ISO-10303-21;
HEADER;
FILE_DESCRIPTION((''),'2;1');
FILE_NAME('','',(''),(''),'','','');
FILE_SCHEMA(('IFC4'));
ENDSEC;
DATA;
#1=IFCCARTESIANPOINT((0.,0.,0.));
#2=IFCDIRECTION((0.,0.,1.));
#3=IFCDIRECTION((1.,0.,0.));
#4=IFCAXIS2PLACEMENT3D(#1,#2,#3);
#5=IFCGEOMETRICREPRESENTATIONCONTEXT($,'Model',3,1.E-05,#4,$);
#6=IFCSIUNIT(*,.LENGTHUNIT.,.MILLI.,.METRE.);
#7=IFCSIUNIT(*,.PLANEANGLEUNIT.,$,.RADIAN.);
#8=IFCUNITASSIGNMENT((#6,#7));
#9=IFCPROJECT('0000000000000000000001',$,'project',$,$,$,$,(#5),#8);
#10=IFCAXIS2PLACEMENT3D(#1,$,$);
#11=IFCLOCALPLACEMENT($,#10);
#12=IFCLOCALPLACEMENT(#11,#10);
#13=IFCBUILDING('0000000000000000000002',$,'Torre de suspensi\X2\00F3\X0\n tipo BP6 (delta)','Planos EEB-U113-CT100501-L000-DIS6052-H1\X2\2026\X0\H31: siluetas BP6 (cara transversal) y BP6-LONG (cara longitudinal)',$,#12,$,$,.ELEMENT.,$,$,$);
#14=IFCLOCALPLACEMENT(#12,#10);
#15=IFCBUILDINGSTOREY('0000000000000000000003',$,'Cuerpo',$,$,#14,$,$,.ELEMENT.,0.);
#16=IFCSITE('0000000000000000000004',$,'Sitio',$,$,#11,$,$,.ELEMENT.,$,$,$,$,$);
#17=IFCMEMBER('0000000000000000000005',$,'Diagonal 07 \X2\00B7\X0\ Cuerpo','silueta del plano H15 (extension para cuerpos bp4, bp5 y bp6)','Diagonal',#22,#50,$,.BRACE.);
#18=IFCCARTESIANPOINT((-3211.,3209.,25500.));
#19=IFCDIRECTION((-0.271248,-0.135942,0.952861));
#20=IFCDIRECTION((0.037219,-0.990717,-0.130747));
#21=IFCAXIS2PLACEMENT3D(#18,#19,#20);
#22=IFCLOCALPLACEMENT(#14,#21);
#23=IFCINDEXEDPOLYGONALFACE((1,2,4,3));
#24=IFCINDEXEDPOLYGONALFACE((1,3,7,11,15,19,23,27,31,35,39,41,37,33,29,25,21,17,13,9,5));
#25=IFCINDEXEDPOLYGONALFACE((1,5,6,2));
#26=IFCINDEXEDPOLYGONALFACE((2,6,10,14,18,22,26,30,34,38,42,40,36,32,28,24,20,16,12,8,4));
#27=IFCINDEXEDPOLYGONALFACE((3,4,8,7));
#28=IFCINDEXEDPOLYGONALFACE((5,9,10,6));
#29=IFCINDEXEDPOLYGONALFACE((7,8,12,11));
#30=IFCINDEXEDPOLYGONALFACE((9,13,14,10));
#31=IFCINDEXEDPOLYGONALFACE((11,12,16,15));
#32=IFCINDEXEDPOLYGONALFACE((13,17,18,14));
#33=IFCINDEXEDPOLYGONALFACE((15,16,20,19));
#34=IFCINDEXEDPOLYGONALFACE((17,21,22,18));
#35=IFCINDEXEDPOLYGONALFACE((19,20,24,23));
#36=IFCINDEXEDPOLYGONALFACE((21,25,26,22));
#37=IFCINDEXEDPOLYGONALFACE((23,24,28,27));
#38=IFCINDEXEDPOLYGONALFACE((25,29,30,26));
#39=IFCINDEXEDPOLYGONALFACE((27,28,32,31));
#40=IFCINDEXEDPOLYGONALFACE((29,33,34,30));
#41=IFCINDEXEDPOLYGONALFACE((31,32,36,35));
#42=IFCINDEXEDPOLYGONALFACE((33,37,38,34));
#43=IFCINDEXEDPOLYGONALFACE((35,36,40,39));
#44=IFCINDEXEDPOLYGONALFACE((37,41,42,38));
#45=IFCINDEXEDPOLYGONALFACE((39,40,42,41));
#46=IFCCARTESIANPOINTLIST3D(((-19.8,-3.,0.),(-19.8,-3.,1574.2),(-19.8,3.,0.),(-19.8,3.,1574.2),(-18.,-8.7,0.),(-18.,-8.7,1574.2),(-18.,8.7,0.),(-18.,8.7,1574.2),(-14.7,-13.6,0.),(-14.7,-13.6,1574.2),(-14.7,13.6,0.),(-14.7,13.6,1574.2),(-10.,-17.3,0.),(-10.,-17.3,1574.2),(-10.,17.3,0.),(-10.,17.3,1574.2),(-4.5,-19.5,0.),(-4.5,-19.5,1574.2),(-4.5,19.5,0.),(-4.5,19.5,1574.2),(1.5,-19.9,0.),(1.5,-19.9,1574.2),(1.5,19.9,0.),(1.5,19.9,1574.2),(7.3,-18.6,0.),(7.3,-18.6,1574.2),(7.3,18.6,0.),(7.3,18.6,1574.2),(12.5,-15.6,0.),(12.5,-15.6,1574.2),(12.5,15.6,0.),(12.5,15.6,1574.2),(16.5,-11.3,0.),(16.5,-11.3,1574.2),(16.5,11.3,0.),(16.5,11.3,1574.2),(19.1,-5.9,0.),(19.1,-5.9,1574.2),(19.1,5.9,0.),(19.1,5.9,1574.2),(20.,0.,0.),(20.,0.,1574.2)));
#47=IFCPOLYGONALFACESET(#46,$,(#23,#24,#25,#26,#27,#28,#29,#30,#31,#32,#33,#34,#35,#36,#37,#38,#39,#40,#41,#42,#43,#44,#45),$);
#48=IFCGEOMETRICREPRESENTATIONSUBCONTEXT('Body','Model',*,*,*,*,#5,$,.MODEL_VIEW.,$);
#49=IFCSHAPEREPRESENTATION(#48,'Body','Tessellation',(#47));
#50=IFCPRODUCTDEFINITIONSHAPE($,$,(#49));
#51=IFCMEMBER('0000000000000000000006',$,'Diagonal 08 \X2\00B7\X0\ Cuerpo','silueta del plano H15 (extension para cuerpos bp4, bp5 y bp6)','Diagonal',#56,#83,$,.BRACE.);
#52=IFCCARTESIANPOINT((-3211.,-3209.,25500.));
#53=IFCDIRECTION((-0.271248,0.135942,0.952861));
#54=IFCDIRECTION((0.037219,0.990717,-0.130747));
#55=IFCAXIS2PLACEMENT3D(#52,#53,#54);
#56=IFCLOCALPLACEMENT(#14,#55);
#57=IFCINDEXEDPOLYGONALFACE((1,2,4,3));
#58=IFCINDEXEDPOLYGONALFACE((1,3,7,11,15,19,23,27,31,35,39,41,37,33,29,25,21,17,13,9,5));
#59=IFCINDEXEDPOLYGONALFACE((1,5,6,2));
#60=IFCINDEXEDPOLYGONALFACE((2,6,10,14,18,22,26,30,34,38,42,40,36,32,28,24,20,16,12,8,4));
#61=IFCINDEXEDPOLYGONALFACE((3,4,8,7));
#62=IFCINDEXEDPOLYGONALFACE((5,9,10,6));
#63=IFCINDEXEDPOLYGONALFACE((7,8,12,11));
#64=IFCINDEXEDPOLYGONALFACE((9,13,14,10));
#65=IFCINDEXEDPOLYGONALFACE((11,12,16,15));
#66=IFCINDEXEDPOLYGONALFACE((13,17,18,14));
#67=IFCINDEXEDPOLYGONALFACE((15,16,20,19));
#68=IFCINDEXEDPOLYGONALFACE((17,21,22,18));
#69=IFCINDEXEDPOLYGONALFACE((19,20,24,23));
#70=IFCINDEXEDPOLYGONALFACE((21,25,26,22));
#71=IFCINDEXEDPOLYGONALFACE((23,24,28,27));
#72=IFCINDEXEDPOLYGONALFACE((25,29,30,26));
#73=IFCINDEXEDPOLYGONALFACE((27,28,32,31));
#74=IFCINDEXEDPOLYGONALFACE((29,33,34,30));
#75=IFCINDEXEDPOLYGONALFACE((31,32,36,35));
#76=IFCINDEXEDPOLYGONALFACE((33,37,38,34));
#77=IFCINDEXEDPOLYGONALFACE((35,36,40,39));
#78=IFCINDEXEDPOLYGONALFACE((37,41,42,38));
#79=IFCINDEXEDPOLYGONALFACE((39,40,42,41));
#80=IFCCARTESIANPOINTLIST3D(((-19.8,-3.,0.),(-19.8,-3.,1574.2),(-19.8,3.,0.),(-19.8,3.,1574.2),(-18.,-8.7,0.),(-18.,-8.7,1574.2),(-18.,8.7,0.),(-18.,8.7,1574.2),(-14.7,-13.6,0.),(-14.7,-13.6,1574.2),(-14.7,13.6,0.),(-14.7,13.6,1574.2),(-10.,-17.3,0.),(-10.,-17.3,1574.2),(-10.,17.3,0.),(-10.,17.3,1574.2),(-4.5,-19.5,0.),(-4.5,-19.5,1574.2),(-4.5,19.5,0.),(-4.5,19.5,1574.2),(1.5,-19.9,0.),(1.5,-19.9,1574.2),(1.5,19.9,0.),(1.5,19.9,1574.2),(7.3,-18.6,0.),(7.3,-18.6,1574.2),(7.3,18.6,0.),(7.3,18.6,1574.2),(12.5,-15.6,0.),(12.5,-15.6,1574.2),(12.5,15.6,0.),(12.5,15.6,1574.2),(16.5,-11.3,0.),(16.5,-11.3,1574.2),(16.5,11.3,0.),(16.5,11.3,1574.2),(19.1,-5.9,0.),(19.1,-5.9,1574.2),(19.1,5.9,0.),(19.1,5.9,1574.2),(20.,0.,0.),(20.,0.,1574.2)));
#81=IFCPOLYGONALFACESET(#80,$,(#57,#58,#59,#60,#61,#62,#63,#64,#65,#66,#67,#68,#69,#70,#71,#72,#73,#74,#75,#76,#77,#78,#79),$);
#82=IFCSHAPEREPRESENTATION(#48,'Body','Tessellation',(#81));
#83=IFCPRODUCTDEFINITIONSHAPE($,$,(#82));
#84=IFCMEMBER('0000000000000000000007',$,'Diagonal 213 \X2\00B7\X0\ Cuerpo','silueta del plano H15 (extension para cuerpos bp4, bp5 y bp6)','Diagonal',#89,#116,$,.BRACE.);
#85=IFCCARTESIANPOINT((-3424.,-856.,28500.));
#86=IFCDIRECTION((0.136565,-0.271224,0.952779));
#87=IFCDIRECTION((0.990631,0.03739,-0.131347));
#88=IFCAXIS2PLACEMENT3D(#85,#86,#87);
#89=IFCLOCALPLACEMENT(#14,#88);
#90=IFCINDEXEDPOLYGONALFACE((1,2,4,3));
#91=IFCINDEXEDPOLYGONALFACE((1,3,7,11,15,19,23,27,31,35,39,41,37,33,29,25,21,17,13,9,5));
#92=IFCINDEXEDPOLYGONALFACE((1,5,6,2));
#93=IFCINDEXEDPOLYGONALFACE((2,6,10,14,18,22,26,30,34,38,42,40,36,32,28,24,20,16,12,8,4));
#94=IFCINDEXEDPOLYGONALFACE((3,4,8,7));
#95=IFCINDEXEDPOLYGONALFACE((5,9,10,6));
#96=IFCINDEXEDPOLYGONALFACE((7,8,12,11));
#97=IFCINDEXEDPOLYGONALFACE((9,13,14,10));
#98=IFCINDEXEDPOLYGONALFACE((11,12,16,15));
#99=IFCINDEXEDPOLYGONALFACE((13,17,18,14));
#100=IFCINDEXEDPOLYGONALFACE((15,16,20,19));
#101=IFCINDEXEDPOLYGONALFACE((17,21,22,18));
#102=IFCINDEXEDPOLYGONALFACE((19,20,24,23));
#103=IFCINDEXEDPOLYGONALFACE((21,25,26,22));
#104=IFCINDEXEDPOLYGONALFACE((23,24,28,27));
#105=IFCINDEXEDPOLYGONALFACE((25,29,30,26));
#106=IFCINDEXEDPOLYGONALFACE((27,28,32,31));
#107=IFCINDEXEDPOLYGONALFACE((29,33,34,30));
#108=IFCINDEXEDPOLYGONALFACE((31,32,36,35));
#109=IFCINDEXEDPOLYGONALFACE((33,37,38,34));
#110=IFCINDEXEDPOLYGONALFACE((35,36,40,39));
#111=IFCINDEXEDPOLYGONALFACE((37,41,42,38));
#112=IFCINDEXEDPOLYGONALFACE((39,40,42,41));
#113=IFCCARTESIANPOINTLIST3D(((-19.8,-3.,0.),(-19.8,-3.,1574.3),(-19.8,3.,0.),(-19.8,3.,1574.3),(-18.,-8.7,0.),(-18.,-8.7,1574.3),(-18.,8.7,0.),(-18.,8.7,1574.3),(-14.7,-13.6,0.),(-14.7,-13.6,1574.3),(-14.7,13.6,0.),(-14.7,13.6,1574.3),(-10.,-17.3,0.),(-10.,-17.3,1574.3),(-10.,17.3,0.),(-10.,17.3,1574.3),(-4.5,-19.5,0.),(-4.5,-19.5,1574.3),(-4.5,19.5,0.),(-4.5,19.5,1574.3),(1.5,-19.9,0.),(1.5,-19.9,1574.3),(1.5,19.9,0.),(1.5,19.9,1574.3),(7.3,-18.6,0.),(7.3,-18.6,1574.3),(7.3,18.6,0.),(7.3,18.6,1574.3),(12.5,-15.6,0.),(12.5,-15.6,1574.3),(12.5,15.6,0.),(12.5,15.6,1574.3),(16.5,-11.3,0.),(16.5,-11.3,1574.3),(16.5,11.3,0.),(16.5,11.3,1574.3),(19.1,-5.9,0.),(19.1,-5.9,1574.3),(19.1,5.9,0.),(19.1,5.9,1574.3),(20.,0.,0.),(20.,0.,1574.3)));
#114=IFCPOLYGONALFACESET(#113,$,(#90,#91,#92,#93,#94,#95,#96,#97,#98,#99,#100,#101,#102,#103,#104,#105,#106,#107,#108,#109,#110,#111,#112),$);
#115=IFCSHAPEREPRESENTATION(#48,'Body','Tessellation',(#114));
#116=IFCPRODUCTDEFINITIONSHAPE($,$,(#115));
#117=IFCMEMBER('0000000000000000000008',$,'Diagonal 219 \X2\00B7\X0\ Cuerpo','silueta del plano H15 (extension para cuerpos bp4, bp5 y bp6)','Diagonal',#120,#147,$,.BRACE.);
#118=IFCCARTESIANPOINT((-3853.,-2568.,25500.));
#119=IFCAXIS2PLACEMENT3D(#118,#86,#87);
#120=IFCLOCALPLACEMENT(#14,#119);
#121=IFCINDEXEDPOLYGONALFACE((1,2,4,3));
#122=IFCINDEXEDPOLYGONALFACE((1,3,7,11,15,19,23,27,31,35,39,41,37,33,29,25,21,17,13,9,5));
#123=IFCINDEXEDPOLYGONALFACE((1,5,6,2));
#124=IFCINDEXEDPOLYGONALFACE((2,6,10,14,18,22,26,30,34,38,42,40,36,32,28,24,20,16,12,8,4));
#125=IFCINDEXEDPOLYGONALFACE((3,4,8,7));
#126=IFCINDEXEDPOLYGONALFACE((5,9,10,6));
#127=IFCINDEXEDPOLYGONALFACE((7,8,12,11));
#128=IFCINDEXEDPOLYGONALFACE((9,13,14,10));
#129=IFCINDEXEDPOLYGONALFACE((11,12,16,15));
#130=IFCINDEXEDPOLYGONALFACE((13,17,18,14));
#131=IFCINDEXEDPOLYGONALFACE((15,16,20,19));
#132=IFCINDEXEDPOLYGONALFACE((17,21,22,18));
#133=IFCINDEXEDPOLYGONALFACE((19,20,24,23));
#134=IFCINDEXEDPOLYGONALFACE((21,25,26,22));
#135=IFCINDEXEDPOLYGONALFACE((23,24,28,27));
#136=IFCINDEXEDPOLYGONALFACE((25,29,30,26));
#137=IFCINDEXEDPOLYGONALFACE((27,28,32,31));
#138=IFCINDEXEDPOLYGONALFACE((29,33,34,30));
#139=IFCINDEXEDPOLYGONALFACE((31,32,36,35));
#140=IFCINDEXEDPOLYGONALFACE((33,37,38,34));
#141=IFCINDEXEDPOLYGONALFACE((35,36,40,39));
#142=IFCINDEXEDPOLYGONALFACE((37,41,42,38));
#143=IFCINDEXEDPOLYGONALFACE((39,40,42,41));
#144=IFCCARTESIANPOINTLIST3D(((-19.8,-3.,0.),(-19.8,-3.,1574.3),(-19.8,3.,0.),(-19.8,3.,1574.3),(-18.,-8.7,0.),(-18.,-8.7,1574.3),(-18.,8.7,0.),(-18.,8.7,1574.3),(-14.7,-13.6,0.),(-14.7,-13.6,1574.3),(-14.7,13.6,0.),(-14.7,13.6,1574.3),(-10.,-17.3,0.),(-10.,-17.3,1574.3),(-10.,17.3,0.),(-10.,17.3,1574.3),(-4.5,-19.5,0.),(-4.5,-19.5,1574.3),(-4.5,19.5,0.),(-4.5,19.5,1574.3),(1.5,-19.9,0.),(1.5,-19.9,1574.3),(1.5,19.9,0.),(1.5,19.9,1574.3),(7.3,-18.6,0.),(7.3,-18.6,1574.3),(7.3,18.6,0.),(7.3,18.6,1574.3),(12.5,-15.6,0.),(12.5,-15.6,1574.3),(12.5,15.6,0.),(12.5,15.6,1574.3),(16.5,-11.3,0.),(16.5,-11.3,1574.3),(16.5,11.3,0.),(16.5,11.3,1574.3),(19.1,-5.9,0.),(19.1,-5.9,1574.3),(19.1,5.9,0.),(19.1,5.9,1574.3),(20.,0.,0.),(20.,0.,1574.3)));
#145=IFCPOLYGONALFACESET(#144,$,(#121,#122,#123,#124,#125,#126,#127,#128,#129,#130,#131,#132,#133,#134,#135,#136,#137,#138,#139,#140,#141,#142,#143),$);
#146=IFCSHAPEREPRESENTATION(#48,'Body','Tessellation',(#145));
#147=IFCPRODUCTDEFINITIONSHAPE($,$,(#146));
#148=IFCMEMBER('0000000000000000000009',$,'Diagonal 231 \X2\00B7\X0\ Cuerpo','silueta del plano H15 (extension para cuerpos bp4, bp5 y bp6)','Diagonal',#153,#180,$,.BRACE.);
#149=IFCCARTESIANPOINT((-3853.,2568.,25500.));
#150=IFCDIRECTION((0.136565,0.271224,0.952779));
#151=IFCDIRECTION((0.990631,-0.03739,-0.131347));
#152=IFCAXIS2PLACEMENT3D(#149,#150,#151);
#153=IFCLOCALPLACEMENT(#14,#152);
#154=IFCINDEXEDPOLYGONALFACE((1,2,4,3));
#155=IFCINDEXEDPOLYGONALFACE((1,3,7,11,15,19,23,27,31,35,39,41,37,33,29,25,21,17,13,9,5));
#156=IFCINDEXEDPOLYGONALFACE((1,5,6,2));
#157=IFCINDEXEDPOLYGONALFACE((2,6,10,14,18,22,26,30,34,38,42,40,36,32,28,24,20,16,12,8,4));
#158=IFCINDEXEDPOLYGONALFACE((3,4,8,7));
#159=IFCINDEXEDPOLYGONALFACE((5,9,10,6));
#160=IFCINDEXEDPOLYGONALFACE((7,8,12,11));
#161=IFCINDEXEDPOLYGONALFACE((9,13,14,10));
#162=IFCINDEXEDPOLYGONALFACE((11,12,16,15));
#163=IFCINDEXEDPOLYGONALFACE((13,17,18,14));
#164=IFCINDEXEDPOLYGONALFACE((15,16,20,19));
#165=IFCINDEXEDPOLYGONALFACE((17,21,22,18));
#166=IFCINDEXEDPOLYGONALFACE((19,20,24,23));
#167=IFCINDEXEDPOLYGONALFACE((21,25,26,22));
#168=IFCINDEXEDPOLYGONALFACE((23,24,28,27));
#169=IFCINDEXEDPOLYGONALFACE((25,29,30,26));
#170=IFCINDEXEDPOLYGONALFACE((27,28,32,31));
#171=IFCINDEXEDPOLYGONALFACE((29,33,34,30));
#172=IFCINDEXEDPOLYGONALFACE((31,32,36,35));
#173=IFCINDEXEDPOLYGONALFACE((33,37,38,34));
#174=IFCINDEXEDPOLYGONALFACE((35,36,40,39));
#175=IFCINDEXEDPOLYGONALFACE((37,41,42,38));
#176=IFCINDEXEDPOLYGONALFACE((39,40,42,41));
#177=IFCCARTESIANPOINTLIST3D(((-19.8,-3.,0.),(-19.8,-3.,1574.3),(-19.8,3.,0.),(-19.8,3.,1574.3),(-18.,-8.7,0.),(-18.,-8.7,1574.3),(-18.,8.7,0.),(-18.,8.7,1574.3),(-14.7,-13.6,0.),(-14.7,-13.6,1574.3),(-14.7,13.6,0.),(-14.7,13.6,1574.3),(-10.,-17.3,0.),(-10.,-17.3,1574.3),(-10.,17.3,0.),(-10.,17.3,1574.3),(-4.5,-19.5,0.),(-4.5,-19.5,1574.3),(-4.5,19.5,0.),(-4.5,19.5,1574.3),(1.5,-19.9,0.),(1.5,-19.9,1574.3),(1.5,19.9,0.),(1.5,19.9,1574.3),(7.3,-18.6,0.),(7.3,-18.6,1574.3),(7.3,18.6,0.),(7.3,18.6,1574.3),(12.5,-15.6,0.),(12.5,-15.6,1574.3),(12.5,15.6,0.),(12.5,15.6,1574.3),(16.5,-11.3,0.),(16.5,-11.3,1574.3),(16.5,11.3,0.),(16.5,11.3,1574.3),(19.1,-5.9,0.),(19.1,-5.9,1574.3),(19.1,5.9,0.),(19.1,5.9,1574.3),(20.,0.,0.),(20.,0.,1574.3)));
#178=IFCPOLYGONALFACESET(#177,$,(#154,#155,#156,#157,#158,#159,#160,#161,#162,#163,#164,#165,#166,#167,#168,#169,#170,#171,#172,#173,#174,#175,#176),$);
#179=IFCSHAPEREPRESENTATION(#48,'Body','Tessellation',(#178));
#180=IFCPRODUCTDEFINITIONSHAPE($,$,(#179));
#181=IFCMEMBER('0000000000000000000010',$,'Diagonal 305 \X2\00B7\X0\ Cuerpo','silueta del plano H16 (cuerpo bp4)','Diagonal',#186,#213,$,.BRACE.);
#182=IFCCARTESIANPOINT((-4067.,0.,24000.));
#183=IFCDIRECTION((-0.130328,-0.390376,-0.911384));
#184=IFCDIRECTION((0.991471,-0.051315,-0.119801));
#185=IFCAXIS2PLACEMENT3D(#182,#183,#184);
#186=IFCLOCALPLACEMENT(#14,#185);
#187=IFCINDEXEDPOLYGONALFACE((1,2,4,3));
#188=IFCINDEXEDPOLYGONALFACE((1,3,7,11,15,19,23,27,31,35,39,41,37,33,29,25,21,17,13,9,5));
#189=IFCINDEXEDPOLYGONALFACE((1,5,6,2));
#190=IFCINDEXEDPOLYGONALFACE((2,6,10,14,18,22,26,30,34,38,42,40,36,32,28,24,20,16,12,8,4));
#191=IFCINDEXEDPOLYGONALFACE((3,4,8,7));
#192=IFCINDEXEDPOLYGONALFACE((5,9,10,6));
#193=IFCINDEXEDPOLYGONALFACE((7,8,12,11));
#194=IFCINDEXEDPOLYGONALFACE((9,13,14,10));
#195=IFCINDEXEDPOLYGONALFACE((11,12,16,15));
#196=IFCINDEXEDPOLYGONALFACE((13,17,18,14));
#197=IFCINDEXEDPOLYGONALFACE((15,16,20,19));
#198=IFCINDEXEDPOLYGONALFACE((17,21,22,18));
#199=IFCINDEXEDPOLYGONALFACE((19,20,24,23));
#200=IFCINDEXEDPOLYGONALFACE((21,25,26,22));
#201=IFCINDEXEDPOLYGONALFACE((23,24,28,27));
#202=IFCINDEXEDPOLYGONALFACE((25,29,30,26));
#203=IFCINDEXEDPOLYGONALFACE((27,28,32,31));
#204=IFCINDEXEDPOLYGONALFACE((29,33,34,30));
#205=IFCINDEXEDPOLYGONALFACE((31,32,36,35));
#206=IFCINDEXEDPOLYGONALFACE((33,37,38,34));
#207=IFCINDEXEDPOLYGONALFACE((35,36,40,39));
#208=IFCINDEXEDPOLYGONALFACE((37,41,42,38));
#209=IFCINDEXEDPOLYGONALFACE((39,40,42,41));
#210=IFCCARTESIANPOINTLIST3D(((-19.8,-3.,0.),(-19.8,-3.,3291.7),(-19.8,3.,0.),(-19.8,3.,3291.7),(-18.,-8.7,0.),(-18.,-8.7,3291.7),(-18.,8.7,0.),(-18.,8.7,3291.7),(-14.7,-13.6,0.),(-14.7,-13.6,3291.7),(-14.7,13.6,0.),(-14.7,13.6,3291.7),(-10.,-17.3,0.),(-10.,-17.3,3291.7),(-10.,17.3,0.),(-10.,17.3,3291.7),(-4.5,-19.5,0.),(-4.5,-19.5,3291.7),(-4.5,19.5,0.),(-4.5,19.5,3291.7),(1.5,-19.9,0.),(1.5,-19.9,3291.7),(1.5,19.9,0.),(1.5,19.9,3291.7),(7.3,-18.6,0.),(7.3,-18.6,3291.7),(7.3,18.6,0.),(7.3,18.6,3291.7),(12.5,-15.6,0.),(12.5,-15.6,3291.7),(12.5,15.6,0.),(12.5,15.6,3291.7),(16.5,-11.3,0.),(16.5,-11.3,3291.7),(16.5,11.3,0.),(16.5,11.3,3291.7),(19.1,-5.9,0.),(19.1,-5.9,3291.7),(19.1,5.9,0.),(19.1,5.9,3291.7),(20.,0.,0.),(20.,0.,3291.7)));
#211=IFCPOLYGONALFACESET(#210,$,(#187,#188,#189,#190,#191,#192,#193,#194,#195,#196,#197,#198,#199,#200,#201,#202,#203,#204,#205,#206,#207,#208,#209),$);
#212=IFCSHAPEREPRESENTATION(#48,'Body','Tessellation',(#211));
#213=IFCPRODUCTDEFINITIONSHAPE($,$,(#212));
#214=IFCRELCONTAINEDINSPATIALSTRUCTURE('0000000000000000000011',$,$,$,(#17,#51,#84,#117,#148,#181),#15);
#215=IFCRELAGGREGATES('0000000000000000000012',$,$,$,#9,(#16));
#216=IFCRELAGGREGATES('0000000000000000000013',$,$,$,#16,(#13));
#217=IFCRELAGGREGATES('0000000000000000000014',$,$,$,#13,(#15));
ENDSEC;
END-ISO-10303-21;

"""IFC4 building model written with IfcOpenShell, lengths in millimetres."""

from ifc_helpers import new_model, si_unit, frame, origin, origin_with_axes, place, context, subcontext, project, spatial, circle, extrude, element, save


model = new_model("IFC4")

# Units and contexts
model_context = context("Model", 3, precision=1e-05, world=origin_with_axes())
body_context = subcontext(model_context, "Body", "Model", "MODEL_VIEW")
ifc_project = project(units=[si_unit("LENGTHUNIT", "METRE", prefix="MILLI"), si_unit("PLANEANGLEUNIT", "RADIAN")], contexts=[model_context])

# Site, building, storey
site_placement = place(None, origin())
site = spatial("IfcSite", under=ifc_project, at=site_placement, Name="Sitio", CompositionType="ELEMENT")
building_placement = place(site_placement, origin())
building = spatial("IfcBuilding", under=site, at=building_placement, Name="Torre de suspensión tipo BP6 (delta)", Description="Planos EEB-U113-CT100501-L000-DIS6052-H1…H31: siluetas BP6 (cara transversal) y BP6-LONG (cara longitudinal)", CompositionType="ELEMENT")
storey_placement = place(building_placement, origin())
storey = spatial("IfcBuildingStorey", under=building, at=storey_placement, Name="Cuerpo", CompositionType="ELEMENT", Elevation=0.0)

# Members
for number, where, z_axis, x_axis, name in (
    (1, (-3211.0, 3209.0, 25500.0), (-0.271248, -0.135942, 0.952861), (0.037219, -0.990717, -0.130747), "Diagonal 07 · Cuerpo"),
    (2, (-3211.0, -3209.0, 25500.0), (-0.271248, 0.135942, 0.952861), (0.037219, 0.990717, -0.130747), "Diagonal 08 · Cuerpo"),
):
    element("IfcMember", number, at=place(storey_placement, frame(where, z_axis=z_axis, x_axis=x_axis)), inside=storey, Name=name, Description="silueta del plano H15 (extension para cuerpos bp4, bp5 y bp6)", ObjectType="Diagonal", PredefinedType="BRACE", context=body_context, shape_type="SweptSolid", body=[
        extrude(circle(Radius=20.0), None, (0.0, 0.0, 1.0), 1574.2),
    ])
member_1_placement = place(storey_placement, frame((-3424.0, -856.0, 28500.0), z_axis=(0.136565, -0.271224, 0.952779), x_axis=(0.990631, 0.03739, -0.131347)))
element("IfcMember", 3, at=member_1_placement, inside=storey, Name="Diagonal 213 · Cuerpo", Description="silueta del plano H15 (extension para cuerpos bp4, bp5 y bp6)", ObjectType="Diagonal", PredefinedType="BRACE", context=body_context, shape_type="SweptSolid", body=[
    extrude(circle(Radius=20.0), None, (0.0, 0.0, 1.0), 1574.3),
])
member_2_placement = place(storey_placement, frame((-3853.0, -2568.0, 25500.0), z_axis=(0.136565, -0.271224, 0.952779), x_axis=(0.990631, 0.03739, -0.131347)))
element("IfcMember", 4, at=member_2_placement, inside=storey, Name="Diagonal 219 · Cuerpo", Description="silueta del plano H15 (extension para cuerpos bp4, bp5 y bp6)", ObjectType="Diagonal", PredefinedType="BRACE", context=body_context, shape_type="SweptSolid", body=[
    extrude(circle(Radius=20.0), None, (0.0, 0.0, 1.0), 1574.3),
])
member_3_placement = place(storey_placement, frame((-3853.0, 2568.0, 25500.0), z_axis=(0.136565, 0.271224, 0.952779), x_axis=(0.990631, -0.03739, -0.131347)))
element("IfcMember", 5, at=member_3_placement, inside=storey, Name="Diagonal 231 · Cuerpo", Description="silueta del plano H15 (extension para cuerpos bp4, bp5 y bp6)", ObjectType="Diagonal", PredefinedType="BRACE", context=body_context, shape_type="SweptSolid", body=[
    extrude(circle(Radius=20.0), None, (0.0, 0.0, 1.0), 1574.3),
])
for number, where, z_axis, x_axis, name in (
    (6, (-4067.0, 0.0, 24000.0), (-0.130328, -0.390376, -0.911384), (0.991471, -0.051315, -0.119801), "Diagonal 305 · Cuerpo"),
):
    element("IfcMember", number, at=place(storey_placement, frame(where, z_axis=z_axis, x_axis=x_axis)), inside=storey, Name=name, Description="silueta del plano H16 (cuerpo bp4)", ObjectType="Diagonal", PredefinedType="BRACE", context=body_context, shape_type="SweptSolid", body=[
        extrude(circle(Radius=20.0), None, (0.0, 0.0, 1.0), 3291.7),
    ])

save(model, "model.ifc")
